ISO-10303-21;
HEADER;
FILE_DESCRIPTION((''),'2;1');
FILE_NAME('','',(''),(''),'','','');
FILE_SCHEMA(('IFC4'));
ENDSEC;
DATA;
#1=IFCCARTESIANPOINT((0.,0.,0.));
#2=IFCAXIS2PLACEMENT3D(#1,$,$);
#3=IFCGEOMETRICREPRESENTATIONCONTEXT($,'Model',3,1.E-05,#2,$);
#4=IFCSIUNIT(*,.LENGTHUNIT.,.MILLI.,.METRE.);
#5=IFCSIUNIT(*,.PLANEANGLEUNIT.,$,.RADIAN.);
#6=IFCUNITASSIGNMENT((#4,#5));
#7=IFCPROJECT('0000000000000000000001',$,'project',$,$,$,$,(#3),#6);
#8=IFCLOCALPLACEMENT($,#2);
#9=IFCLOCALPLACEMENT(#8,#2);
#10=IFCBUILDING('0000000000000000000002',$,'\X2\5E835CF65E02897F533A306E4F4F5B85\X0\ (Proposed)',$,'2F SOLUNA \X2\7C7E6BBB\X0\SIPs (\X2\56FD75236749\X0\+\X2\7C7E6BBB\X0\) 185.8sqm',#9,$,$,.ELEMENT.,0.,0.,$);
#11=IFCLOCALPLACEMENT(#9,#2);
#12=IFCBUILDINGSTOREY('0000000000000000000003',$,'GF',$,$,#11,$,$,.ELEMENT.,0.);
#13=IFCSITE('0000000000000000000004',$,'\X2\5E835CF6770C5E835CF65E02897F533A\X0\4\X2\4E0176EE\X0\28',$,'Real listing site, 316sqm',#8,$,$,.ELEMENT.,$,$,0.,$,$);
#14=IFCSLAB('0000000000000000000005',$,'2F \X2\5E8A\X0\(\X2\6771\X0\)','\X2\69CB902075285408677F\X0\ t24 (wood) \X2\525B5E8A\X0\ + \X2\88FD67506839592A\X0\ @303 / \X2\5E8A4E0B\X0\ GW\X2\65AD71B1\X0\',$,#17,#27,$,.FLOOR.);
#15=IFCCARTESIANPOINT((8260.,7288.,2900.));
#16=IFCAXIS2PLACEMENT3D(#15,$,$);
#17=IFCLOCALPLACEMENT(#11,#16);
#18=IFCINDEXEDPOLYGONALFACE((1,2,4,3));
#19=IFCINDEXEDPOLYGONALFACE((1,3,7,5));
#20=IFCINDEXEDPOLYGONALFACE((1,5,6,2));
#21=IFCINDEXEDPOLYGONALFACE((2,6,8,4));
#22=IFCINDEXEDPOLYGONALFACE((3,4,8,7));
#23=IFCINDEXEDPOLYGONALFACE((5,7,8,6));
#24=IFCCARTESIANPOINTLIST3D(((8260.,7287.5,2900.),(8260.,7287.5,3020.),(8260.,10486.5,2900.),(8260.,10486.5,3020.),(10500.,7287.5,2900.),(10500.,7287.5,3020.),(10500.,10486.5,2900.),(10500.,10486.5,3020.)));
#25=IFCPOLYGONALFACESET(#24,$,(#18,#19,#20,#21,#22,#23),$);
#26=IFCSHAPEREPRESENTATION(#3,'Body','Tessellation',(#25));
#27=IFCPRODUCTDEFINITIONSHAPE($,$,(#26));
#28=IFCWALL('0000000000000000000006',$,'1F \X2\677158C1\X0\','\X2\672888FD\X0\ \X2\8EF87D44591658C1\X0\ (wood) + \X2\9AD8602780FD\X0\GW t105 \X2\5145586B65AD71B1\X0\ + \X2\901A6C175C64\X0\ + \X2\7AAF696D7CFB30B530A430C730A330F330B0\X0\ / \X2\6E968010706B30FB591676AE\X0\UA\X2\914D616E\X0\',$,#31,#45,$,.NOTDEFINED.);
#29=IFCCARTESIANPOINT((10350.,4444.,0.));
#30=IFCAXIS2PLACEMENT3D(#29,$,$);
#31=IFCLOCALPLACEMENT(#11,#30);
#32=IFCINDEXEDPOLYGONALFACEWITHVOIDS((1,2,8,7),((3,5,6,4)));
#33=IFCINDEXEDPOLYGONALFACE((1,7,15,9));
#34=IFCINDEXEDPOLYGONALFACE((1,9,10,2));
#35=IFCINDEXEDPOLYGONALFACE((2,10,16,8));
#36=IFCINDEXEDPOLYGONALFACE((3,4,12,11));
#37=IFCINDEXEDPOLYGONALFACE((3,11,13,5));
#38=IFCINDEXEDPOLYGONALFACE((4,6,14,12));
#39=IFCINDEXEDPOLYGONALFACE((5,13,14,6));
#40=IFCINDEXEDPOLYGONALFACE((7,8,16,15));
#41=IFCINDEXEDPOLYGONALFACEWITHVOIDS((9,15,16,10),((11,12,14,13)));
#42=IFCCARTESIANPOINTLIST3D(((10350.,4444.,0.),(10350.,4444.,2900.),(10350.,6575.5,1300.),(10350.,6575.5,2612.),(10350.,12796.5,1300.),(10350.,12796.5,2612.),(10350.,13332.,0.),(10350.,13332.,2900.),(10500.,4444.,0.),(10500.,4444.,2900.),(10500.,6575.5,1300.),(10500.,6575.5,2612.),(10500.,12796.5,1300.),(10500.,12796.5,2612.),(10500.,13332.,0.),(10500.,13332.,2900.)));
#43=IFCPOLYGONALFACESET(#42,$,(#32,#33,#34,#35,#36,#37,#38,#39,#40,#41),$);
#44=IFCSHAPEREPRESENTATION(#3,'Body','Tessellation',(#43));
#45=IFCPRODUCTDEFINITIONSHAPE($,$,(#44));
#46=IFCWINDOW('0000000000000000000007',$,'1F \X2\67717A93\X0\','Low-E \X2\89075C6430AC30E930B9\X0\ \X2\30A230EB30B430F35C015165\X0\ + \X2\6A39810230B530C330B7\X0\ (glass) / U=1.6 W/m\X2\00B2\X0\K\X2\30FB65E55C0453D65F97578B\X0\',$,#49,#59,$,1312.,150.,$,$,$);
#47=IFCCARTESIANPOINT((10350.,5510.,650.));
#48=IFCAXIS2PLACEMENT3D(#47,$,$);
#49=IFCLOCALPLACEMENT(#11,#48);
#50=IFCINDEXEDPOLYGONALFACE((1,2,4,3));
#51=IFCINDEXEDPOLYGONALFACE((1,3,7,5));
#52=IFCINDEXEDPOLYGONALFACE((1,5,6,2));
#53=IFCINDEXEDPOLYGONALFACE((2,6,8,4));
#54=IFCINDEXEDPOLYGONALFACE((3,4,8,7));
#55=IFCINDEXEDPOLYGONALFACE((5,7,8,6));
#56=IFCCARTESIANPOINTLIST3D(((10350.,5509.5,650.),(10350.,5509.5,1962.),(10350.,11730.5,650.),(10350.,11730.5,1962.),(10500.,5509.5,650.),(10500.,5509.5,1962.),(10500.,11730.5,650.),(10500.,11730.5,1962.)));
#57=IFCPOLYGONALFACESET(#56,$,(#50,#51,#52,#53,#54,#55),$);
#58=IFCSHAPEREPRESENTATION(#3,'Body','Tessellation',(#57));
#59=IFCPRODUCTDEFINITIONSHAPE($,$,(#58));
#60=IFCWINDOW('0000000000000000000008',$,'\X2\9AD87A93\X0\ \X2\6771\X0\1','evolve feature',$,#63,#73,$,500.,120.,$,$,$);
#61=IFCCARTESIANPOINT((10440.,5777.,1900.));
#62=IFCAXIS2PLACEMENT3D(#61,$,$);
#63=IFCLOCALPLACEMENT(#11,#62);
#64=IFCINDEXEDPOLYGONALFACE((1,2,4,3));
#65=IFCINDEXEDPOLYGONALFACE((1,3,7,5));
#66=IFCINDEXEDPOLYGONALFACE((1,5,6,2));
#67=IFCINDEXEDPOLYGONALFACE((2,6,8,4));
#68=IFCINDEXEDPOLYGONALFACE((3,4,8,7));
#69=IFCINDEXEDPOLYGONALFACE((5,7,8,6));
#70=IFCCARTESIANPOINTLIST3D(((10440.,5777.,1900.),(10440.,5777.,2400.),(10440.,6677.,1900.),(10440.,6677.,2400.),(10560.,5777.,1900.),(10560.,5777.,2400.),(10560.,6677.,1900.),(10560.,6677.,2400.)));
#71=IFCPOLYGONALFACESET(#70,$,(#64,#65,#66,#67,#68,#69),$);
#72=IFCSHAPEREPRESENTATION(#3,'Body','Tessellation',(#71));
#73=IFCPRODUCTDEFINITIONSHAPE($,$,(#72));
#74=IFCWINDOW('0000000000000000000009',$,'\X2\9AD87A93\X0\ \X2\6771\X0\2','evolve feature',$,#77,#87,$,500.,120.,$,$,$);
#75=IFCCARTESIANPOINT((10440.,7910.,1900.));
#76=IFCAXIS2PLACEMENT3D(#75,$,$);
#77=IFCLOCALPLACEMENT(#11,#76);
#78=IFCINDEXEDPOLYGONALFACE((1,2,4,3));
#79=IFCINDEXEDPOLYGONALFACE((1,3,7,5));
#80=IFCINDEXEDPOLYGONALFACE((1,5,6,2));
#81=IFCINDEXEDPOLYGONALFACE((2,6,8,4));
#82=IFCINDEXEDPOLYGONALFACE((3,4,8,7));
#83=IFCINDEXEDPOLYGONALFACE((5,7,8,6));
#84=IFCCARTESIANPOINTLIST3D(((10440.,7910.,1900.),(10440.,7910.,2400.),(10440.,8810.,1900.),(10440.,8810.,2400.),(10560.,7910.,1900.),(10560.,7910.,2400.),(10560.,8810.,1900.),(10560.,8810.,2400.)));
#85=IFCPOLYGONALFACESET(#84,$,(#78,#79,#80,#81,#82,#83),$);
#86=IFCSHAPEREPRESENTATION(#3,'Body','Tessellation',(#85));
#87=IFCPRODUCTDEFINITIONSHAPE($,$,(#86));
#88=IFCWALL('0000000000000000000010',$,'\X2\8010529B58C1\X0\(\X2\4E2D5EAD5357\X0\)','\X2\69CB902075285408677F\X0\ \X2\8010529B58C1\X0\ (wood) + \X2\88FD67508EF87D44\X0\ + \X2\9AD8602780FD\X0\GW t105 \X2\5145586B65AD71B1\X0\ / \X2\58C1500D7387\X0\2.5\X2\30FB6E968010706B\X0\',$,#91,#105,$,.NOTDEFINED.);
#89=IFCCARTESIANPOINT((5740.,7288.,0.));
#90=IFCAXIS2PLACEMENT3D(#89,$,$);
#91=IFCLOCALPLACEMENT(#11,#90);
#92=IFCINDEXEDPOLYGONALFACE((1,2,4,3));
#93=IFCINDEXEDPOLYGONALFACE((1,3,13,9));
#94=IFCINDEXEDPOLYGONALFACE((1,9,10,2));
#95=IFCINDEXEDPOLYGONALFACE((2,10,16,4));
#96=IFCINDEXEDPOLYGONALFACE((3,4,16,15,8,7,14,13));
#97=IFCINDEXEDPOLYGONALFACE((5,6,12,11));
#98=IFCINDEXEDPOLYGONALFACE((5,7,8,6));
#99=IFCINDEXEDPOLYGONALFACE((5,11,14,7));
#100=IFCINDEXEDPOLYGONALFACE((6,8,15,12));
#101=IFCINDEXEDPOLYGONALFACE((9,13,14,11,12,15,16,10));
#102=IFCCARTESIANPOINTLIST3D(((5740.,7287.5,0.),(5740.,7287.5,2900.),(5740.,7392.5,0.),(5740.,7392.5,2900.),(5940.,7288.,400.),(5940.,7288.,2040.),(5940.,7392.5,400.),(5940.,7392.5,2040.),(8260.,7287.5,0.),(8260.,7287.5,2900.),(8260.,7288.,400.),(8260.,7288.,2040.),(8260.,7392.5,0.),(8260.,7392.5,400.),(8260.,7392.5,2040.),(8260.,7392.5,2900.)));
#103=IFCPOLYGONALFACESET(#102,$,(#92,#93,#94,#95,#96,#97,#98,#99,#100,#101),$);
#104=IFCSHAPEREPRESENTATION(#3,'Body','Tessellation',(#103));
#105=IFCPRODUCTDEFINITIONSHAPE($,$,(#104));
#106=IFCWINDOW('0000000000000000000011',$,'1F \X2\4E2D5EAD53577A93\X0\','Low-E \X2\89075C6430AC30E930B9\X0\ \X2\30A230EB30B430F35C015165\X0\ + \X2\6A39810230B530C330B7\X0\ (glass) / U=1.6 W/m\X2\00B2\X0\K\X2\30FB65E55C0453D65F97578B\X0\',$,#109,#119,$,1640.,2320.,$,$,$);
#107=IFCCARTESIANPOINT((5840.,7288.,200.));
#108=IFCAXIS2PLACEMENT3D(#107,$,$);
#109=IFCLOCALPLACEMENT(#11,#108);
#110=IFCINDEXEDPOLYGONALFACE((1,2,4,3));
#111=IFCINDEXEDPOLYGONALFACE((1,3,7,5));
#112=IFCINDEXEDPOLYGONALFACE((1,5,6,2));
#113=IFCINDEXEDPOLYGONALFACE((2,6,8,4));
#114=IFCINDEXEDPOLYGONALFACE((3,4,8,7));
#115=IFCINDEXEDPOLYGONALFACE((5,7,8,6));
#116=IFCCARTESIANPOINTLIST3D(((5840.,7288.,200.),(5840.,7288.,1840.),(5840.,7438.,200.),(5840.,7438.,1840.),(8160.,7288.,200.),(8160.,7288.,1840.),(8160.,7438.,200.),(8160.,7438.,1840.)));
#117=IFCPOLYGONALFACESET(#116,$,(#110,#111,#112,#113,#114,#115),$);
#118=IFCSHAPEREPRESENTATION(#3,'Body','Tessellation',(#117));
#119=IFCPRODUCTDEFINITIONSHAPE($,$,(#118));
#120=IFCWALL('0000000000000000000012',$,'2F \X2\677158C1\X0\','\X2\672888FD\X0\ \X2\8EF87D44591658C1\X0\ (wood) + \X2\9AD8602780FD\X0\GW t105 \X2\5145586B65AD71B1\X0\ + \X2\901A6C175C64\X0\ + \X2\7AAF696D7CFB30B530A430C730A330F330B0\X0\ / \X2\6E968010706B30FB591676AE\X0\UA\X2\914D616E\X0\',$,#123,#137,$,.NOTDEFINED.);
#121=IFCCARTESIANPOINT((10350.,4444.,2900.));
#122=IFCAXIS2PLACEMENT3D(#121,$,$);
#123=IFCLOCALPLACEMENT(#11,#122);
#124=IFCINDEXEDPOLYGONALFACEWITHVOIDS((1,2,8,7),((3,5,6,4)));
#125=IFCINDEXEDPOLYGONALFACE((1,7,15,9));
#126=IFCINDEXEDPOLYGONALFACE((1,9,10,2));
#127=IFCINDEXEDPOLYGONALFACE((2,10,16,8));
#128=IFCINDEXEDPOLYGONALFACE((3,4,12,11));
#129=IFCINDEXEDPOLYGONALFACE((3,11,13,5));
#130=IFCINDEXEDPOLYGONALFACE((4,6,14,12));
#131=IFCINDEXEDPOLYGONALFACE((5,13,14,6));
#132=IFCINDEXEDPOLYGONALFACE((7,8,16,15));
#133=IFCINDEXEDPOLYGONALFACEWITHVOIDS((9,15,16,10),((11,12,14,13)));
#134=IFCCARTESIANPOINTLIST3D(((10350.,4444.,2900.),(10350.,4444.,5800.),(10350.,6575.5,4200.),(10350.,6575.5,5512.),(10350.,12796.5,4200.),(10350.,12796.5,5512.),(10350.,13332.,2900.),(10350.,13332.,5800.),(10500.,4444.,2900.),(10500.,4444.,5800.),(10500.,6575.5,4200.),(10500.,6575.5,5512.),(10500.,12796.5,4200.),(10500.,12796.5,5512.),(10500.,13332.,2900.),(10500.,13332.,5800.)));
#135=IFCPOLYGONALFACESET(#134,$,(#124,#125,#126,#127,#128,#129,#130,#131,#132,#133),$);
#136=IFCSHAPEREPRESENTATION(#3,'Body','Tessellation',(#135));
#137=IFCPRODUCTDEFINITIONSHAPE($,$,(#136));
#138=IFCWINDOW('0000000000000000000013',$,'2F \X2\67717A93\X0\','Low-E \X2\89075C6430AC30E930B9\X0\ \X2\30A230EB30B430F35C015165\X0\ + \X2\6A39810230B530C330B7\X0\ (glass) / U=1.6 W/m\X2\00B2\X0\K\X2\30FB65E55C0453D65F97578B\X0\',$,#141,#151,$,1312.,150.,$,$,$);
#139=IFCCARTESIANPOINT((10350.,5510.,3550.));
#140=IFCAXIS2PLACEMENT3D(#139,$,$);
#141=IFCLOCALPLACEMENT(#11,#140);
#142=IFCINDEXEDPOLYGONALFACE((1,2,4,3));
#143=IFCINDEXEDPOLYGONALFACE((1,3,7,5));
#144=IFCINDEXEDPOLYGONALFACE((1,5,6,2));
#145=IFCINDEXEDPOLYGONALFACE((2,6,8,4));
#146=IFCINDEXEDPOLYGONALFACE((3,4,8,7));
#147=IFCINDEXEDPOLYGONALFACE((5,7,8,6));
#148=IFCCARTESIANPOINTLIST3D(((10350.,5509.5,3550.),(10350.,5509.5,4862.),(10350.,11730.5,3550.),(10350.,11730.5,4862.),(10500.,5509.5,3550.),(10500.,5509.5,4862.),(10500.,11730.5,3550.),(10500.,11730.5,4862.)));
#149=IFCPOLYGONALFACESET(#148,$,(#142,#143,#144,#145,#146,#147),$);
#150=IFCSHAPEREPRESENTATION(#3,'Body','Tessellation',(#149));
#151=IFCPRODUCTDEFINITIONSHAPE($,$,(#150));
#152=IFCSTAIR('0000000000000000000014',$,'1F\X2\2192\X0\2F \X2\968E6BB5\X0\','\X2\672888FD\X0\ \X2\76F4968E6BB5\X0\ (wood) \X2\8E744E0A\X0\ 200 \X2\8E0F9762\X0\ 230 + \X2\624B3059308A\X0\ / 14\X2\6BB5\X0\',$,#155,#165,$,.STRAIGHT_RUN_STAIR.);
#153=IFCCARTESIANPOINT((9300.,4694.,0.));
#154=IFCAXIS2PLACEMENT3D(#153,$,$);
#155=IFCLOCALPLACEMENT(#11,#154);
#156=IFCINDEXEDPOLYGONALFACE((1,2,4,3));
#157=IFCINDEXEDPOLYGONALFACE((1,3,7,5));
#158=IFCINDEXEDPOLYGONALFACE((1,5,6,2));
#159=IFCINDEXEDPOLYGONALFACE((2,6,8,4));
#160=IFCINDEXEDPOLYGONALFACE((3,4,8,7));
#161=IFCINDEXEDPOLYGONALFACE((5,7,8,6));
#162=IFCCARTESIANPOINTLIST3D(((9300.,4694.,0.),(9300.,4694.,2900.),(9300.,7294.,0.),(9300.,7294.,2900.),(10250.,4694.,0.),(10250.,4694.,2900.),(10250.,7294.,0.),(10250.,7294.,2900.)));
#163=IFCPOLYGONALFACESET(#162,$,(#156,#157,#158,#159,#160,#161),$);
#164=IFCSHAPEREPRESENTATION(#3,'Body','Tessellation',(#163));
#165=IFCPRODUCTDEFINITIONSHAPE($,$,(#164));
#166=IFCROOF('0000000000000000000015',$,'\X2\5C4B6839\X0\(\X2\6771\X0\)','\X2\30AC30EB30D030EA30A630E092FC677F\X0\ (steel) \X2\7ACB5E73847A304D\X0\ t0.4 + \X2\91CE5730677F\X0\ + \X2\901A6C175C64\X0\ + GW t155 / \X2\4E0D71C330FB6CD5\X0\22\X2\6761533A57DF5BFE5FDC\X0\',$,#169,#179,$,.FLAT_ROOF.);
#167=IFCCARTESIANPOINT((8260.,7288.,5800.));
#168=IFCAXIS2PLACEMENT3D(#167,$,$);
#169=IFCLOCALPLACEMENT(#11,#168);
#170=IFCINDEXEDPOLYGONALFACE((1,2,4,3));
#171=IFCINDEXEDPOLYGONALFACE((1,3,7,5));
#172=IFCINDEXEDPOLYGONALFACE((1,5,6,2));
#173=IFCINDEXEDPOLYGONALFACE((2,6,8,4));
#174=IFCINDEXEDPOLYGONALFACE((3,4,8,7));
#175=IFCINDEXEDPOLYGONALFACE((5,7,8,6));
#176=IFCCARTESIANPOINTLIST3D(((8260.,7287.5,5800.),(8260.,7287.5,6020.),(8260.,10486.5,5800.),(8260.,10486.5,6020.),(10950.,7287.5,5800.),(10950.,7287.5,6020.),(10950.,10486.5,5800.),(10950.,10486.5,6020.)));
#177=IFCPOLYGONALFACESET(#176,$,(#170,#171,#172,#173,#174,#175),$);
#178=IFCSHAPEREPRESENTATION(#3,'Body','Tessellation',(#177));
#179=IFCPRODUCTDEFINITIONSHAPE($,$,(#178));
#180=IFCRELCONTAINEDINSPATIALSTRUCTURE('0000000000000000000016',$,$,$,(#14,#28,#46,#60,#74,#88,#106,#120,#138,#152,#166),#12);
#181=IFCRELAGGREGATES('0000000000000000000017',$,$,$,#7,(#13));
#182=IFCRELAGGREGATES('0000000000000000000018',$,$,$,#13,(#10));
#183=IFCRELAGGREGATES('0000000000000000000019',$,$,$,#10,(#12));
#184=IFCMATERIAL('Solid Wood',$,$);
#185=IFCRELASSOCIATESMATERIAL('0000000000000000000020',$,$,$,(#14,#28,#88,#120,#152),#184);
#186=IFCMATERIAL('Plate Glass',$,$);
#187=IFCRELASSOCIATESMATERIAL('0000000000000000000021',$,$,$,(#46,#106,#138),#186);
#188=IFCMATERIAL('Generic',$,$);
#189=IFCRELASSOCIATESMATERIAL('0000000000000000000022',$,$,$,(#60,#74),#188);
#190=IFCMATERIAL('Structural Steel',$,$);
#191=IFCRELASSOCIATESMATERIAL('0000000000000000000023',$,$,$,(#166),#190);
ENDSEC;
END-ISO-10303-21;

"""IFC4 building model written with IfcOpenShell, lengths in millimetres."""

from ifc_helpers import new_model, si_unit, frame, frame_2d, origin, place, context, project, spatial, rectangle, extrude, material, element, fill, save


model = new_model("IFC4")

# Units and contexts
model_context = context("Model", 3, precision=1e-05, world=origin())
ifc_project = project(units=[si_unit("LENGTHUNIT", "METRE", prefix="MILLI"), si_unit("PLANEANGLEUNIT", "RADIAN")], contexts=[model_context])

# Site, building, storey
site_placement = place(None, origin())
site = spatial("IfcSite", under=ifc_project, at=site_placement, Name="広島県広島市西区4丁目28", ObjectType="Real listing site, 316sqm", CompositionType="ELEMENT", RefElevation=0.0)
building_placement = place(site_placement, origin())
building = spatial("IfcBuilding", under=site, at=building_placement, Name="広島市西区の住宅 (Proposed)", ObjectType="2F SOLUNA 籾殻SIPs (国産杉+籾殻) 185.8sqm", CompositionType="ELEMENT", ElevationOfRefHeight=0.0, ElevationOfTerrain=0.0)
storey_placement = place(building_placement, origin())
storey = spatial("IfcBuildingStorey", under=building, at=storey_placement, Name="GF", CompositionType="ELEMENT", Elevation=0.0)

# Slab
ifc_material_1 = material(Name="Solid Wood")
slab_1_placement = place(storey_placement, frame((8260.0, 7288.0, 2900.0)))
element("IfcSlab", 1, at=slab_1_placement, inside=storey, material=ifc_material_1, Name="2F 床(東)", Description="構造用合板 t24 (wood) 剛床 + 製材根太 @303 / 床下 GW断熱", PredefinedType="FLOOR", context=model_context, shape_type="SweptSolid", body=[
    extrude(rectangle(XDim=2240.0, YDim=3199.0, at=frame_2d((1120.0, 1599.0))), frame((8260.0, 7288.0, 2900.0)), (0.0, 0.0, 1.0), 120.0),
])

# Wall, openings, windows
wall_1_placement = place(storey_placement, frame((10350.0, 4444.0, 0.0)))
wall_1 = element("IfcWall", 2, at=wall_1_placement, inside=storey, material=ifc_material_1, Name="1F 東壁", Description="木製 軸組外壁 (wood) + 高性能GW t105 充填断熱 + 通気層 + 窯業系サイディング / 準耐火・外皮UA配慮", PredefinedType="NOTDEFINED", context=model_context, shape_type="SweptSolid", body=[
    extrude(rectangle(XDim=150.0, YDim=8888.0, at=frame_2d((75.0, 4444.0))), frame((10350.0, 4444.0, 0.0)), (0.0, 0.0, 1.0), 2900.0),
])
opening_1_placement = place(storey_placement, frame((10350.0, 5510.0, 650.0)))
opening_1 = element("IfcOpeningElement", 3, at=opening_1_placement, cuts=wall_1, PredefinedType="NOTDEFINED", context=model_context, shape_type="SweptSolid", body=[
    extrude(rectangle(XDim=150.0, YDim=6221.0, at=frame_2d((75.0, 3110.0))), frame((10350.0, 5510.0, 650.0)), (0.0, 0.0, 1.0), 1312.0),
])
opening_2_placement = place(storey_placement, frame((10440.0, 5777.0, 1900.0)))
opening_2 = element("IfcOpeningElement", 4, at=opening_2_placement, cuts=wall_1, PredefinedType="NOTDEFINED", context=model_context, shape_type="SweptSolid", body=[
    extrude(rectangle(XDim=120.0, YDim=900.0, at=frame_2d((60.0, 450.0))), frame((10440.0, 5777.0, 1900.0)), (0.0, 0.0, 1.0), 500.0),
])
opening_3_placement = place(storey_placement, frame((10440.0, 7910.0, 1900.0)))
opening_3 = element("IfcOpeningElement", 5, at=opening_3_placement, cuts=wall_1, PredefinedType="NOTDEFINED", context=model_context, shape_type="SweptSolid", body=[
    extrude(rectangle(XDim=120.0, YDim=900.0, at=frame_2d((60.0, 450.0))), frame((10440.0, 7910.0, 1900.0)), (0.0, 0.0, 1.0), 500.0),
])
ifc_material_2 = material(Name="Plate Glass")
window_1_placement = place(storey_placement, frame((10350.0, 5510.0, 650.0)))
window_1 = element("IfcWindow", 6, at=window_1_placement, inside=storey, material=ifc_material_2, Name="1F 東窓", Description="Low-E 複層ガラス アルゴン封入 + 樹脂サッシ (glass) / U=1.6 W/m²K・日射取得型", OverallHeight=1312.0, OverallWidth=150.0, context=model_context, shape_type="SweptSolid", body=[
    extrude(rectangle(XDim=150.0, YDim=6221.0, at=frame_2d((75.0, 3110.0))), frame((10350.0, 5510.0, 650.0)), (0.0, 0.0, 1.0), 1312.0),
])
fill(opening_1, window_1)
ifc_material_3 = material(Name="Generic")
window_2_placement = place(storey_placement, frame((10440.0, 5777.0, 1900.0)))
window_2 = element("IfcWindow", 7, at=window_2_placement, inside=storey, material=ifc_material_3, Name="高窓 東1", Description="evolve feature", OverallHeight=500.0, OverallWidth=120.0, context=model_context, shape_type="SweptSolid", body=[
    extrude(rectangle(XDim=120.0, YDim=900.0, at=frame_2d((60.0, 450.0))), frame((10440.0, 5777.0, 1900.0)), (0.0, 0.0, 1.0), 500.0),
])
fill(opening_2, window_2)
window_3_placement = place(storey_placement, frame((10440.0, 7910.0, 1900.0)))
window_3 = element("IfcWindow", 8, at=window_3_placement, inside=storey, material=ifc_material_3, Name="高窓 東2", Description="evolve feature", OverallHeight=500.0, OverallWidth=120.0, context=model_context, shape_type="SweptSolid", body=[
    extrude(rectangle(XDim=120.0, YDim=900.0, at=frame_2d((60.0, 450.0))), frame((10440.0, 7910.0, 1900.0)), (0.0, 0.0, 1.0), 500.0),
])
fill(opening_3, window_3)

# Wall, opening, window
wall_2_placement = place(storey_placement, frame((5740.0, 7288.0, 0.0)))
wall_2 = element("IfcWall", 9, at=wall_2_placement, inside=storey, material=ifc_material_1, Name="耐力壁(中庭南)", Description="構造用合板 耐力壁 (wood) + 製材軸組 + 高性能GW t105 充填断熱 / 壁倍率2.5・準耐火", PredefinedType="NOTDEFINED", context=model_context, shape_type="SweptSolid", body=[
    extrude(rectangle(XDim=2520.0, YDim=105.0, at=frame_2d((1260.0, 52.0))), frame((5740.0, 7288.0, 0.0)), (0.0, 0.0, 1.0), 2900.0),
])
opening_4_placement = place(storey_placement, frame((5840.0, 7288.0, 200.0)))
opening_4 = element("IfcOpeningElement", 10, at=opening_4_placement, cuts=wall_2, PredefinedType="NOTDEFINED", context=model_context, shape_type="SweptSolid", body=[
    extrude(rectangle(XDim=2320.0, YDim=150.0, at=frame_2d((1160.0, 75.0))), frame((5840.0, 7288.0, 200.0)), (0.0, 0.0, 1.0), 1640.0),
])
window_4_placement = place(storey_placement, frame((5840.0, 7288.0, 200.0)))
window_4 = element("IfcWindow", 11, at=window_4_placement, inside=storey, material=ifc_material_2, Name="1F 中庭南窓", Description="Low-E 複層ガラス アルゴン封入 + 樹脂サッシ (glass) / U=1.6 W/m²K・日射取得型", OverallHeight=1640.0, OverallWidth=2320.0, context=model_context, shape_type="SweptSolid", body=[
    extrude(rectangle(XDim=2320.0, YDim=150.0, at=frame_2d((1160.0, 75.0))), frame((5840.0, 7288.0, 200.0)), (0.0, 0.0, 1.0), 1640.0),
])
fill(opening_4, window_4)

# Wall, opening, window
wall_3_placement = place(storey_placement, frame((10350.0, 4444.0, 2900.0)))
wall_3 = element("IfcWall", 12, at=wall_3_placement, inside=storey, material=ifc_material_1, Name="2F 東壁", Description="木製 軸組外壁 (wood) + 高性能GW t105 充填断熱 + 通気層 + 窯業系サイディング / 準耐火・外皮UA配慮", PredefinedType="NOTDEFINED", context=model_context, shape_type="SweptSolid", body=[
    extrude(rectangle(XDim=150.0, YDim=8888.0, at=frame_2d((75.0, 4444.0))), frame((10350.0, 4444.0, 2900.0)), (0.0, 0.0, 1.0), 2900.0),
])
opening_5_placement = place(storey_placement, frame((10350.0, 5510.0, 3550.0)))
opening_5 = element("IfcOpeningElement", 13, at=opening_5_placement, cuts=wall_3, PredefinedType="NOTDEFINED", context=model_context, shape_type="SweptSolid", body=[
    extrude(rectangle(XDim=150.0, YDim=6221.0, at=frame_2d((75.0, 3110.0))), frame((10350.0, 5510.0, 3550.0)), (0.0, 0.0, 1.0), 1312.0),
])
window_5_placement = place(storey_placement, frame((10350.0, 5510.0, 3550.0)))
window_5 = element("IfcWindow", 14, at=window_5_placement, inside=storey, material=ifc_material_2, Name="2F 東窓", Description="Low-E 複層ガラス アルゴン封入 + 樹脂サッシ (glass) / U=1.6 W/m²K・日射取得型", OverallHeight=1312.0, OverallWidth=150.0, context=model_context, shape_type="SweptSolid", body=[
    extrude(rectangle(XDim=150.0, YDim=6221.0, at=frame_2d((75.0, 3110.0))), frame((10350.0, 5510.0, 3550.0)), (0.0, 0.0, 1.0), 1312.0),
])
fill(opening_5, window_5)

# Stair
stair_placement = place(storey_placement, frame((9300.0, 4694.0, 0.0)))
element("IfcStair", 15, at=stair_placement, inside=storey, material=ifc_material_1, Name="1F→2F 階段", Description="木製 直階段 (wood) 蹴上 200 踏面 230 + 手すり / 14段", PredefinedType="STRAIGHT_RUN_STAIR", context=model_context, shape_type="SweptSolid", body=[
    extrude(rectangle(XDim=950.0, YDim=2600.0, at=frame_2d((475.0, 1300.0))), frame((9300.0, 4694.0, 0.0)), (0.0, 0.0, 1.0), 2900.0),
])

# Roof
ifc_material_4 = material(Name="Structural Steel")
roof_placement = place(storey_placement, frame((8260.0, 7288.0, 5800.0)))
element("IfcRoof", 16, at=roof_placement, inside=storey, material=ifc_material_4, Name="屋根(東)", Description="ガルバリウム鋼板 (steel) 立平葺き t0.4 + 野地板 + 通気層 + GW t155 / 不燃・法22条区域対応", PredefinedType="FLAT_ROOF", context=model_context, shape_type="SweptSolid", body=[
    extrude(rectangle(XDim=2690.0, YDim=3199.0, at=frame_2d((1345.0, 1599.0))), frame((8260.0, 7288.0, 5800.0)), (0.0, 0.0, 1.0), 220.0),
])

save(model, "model.ifc")
